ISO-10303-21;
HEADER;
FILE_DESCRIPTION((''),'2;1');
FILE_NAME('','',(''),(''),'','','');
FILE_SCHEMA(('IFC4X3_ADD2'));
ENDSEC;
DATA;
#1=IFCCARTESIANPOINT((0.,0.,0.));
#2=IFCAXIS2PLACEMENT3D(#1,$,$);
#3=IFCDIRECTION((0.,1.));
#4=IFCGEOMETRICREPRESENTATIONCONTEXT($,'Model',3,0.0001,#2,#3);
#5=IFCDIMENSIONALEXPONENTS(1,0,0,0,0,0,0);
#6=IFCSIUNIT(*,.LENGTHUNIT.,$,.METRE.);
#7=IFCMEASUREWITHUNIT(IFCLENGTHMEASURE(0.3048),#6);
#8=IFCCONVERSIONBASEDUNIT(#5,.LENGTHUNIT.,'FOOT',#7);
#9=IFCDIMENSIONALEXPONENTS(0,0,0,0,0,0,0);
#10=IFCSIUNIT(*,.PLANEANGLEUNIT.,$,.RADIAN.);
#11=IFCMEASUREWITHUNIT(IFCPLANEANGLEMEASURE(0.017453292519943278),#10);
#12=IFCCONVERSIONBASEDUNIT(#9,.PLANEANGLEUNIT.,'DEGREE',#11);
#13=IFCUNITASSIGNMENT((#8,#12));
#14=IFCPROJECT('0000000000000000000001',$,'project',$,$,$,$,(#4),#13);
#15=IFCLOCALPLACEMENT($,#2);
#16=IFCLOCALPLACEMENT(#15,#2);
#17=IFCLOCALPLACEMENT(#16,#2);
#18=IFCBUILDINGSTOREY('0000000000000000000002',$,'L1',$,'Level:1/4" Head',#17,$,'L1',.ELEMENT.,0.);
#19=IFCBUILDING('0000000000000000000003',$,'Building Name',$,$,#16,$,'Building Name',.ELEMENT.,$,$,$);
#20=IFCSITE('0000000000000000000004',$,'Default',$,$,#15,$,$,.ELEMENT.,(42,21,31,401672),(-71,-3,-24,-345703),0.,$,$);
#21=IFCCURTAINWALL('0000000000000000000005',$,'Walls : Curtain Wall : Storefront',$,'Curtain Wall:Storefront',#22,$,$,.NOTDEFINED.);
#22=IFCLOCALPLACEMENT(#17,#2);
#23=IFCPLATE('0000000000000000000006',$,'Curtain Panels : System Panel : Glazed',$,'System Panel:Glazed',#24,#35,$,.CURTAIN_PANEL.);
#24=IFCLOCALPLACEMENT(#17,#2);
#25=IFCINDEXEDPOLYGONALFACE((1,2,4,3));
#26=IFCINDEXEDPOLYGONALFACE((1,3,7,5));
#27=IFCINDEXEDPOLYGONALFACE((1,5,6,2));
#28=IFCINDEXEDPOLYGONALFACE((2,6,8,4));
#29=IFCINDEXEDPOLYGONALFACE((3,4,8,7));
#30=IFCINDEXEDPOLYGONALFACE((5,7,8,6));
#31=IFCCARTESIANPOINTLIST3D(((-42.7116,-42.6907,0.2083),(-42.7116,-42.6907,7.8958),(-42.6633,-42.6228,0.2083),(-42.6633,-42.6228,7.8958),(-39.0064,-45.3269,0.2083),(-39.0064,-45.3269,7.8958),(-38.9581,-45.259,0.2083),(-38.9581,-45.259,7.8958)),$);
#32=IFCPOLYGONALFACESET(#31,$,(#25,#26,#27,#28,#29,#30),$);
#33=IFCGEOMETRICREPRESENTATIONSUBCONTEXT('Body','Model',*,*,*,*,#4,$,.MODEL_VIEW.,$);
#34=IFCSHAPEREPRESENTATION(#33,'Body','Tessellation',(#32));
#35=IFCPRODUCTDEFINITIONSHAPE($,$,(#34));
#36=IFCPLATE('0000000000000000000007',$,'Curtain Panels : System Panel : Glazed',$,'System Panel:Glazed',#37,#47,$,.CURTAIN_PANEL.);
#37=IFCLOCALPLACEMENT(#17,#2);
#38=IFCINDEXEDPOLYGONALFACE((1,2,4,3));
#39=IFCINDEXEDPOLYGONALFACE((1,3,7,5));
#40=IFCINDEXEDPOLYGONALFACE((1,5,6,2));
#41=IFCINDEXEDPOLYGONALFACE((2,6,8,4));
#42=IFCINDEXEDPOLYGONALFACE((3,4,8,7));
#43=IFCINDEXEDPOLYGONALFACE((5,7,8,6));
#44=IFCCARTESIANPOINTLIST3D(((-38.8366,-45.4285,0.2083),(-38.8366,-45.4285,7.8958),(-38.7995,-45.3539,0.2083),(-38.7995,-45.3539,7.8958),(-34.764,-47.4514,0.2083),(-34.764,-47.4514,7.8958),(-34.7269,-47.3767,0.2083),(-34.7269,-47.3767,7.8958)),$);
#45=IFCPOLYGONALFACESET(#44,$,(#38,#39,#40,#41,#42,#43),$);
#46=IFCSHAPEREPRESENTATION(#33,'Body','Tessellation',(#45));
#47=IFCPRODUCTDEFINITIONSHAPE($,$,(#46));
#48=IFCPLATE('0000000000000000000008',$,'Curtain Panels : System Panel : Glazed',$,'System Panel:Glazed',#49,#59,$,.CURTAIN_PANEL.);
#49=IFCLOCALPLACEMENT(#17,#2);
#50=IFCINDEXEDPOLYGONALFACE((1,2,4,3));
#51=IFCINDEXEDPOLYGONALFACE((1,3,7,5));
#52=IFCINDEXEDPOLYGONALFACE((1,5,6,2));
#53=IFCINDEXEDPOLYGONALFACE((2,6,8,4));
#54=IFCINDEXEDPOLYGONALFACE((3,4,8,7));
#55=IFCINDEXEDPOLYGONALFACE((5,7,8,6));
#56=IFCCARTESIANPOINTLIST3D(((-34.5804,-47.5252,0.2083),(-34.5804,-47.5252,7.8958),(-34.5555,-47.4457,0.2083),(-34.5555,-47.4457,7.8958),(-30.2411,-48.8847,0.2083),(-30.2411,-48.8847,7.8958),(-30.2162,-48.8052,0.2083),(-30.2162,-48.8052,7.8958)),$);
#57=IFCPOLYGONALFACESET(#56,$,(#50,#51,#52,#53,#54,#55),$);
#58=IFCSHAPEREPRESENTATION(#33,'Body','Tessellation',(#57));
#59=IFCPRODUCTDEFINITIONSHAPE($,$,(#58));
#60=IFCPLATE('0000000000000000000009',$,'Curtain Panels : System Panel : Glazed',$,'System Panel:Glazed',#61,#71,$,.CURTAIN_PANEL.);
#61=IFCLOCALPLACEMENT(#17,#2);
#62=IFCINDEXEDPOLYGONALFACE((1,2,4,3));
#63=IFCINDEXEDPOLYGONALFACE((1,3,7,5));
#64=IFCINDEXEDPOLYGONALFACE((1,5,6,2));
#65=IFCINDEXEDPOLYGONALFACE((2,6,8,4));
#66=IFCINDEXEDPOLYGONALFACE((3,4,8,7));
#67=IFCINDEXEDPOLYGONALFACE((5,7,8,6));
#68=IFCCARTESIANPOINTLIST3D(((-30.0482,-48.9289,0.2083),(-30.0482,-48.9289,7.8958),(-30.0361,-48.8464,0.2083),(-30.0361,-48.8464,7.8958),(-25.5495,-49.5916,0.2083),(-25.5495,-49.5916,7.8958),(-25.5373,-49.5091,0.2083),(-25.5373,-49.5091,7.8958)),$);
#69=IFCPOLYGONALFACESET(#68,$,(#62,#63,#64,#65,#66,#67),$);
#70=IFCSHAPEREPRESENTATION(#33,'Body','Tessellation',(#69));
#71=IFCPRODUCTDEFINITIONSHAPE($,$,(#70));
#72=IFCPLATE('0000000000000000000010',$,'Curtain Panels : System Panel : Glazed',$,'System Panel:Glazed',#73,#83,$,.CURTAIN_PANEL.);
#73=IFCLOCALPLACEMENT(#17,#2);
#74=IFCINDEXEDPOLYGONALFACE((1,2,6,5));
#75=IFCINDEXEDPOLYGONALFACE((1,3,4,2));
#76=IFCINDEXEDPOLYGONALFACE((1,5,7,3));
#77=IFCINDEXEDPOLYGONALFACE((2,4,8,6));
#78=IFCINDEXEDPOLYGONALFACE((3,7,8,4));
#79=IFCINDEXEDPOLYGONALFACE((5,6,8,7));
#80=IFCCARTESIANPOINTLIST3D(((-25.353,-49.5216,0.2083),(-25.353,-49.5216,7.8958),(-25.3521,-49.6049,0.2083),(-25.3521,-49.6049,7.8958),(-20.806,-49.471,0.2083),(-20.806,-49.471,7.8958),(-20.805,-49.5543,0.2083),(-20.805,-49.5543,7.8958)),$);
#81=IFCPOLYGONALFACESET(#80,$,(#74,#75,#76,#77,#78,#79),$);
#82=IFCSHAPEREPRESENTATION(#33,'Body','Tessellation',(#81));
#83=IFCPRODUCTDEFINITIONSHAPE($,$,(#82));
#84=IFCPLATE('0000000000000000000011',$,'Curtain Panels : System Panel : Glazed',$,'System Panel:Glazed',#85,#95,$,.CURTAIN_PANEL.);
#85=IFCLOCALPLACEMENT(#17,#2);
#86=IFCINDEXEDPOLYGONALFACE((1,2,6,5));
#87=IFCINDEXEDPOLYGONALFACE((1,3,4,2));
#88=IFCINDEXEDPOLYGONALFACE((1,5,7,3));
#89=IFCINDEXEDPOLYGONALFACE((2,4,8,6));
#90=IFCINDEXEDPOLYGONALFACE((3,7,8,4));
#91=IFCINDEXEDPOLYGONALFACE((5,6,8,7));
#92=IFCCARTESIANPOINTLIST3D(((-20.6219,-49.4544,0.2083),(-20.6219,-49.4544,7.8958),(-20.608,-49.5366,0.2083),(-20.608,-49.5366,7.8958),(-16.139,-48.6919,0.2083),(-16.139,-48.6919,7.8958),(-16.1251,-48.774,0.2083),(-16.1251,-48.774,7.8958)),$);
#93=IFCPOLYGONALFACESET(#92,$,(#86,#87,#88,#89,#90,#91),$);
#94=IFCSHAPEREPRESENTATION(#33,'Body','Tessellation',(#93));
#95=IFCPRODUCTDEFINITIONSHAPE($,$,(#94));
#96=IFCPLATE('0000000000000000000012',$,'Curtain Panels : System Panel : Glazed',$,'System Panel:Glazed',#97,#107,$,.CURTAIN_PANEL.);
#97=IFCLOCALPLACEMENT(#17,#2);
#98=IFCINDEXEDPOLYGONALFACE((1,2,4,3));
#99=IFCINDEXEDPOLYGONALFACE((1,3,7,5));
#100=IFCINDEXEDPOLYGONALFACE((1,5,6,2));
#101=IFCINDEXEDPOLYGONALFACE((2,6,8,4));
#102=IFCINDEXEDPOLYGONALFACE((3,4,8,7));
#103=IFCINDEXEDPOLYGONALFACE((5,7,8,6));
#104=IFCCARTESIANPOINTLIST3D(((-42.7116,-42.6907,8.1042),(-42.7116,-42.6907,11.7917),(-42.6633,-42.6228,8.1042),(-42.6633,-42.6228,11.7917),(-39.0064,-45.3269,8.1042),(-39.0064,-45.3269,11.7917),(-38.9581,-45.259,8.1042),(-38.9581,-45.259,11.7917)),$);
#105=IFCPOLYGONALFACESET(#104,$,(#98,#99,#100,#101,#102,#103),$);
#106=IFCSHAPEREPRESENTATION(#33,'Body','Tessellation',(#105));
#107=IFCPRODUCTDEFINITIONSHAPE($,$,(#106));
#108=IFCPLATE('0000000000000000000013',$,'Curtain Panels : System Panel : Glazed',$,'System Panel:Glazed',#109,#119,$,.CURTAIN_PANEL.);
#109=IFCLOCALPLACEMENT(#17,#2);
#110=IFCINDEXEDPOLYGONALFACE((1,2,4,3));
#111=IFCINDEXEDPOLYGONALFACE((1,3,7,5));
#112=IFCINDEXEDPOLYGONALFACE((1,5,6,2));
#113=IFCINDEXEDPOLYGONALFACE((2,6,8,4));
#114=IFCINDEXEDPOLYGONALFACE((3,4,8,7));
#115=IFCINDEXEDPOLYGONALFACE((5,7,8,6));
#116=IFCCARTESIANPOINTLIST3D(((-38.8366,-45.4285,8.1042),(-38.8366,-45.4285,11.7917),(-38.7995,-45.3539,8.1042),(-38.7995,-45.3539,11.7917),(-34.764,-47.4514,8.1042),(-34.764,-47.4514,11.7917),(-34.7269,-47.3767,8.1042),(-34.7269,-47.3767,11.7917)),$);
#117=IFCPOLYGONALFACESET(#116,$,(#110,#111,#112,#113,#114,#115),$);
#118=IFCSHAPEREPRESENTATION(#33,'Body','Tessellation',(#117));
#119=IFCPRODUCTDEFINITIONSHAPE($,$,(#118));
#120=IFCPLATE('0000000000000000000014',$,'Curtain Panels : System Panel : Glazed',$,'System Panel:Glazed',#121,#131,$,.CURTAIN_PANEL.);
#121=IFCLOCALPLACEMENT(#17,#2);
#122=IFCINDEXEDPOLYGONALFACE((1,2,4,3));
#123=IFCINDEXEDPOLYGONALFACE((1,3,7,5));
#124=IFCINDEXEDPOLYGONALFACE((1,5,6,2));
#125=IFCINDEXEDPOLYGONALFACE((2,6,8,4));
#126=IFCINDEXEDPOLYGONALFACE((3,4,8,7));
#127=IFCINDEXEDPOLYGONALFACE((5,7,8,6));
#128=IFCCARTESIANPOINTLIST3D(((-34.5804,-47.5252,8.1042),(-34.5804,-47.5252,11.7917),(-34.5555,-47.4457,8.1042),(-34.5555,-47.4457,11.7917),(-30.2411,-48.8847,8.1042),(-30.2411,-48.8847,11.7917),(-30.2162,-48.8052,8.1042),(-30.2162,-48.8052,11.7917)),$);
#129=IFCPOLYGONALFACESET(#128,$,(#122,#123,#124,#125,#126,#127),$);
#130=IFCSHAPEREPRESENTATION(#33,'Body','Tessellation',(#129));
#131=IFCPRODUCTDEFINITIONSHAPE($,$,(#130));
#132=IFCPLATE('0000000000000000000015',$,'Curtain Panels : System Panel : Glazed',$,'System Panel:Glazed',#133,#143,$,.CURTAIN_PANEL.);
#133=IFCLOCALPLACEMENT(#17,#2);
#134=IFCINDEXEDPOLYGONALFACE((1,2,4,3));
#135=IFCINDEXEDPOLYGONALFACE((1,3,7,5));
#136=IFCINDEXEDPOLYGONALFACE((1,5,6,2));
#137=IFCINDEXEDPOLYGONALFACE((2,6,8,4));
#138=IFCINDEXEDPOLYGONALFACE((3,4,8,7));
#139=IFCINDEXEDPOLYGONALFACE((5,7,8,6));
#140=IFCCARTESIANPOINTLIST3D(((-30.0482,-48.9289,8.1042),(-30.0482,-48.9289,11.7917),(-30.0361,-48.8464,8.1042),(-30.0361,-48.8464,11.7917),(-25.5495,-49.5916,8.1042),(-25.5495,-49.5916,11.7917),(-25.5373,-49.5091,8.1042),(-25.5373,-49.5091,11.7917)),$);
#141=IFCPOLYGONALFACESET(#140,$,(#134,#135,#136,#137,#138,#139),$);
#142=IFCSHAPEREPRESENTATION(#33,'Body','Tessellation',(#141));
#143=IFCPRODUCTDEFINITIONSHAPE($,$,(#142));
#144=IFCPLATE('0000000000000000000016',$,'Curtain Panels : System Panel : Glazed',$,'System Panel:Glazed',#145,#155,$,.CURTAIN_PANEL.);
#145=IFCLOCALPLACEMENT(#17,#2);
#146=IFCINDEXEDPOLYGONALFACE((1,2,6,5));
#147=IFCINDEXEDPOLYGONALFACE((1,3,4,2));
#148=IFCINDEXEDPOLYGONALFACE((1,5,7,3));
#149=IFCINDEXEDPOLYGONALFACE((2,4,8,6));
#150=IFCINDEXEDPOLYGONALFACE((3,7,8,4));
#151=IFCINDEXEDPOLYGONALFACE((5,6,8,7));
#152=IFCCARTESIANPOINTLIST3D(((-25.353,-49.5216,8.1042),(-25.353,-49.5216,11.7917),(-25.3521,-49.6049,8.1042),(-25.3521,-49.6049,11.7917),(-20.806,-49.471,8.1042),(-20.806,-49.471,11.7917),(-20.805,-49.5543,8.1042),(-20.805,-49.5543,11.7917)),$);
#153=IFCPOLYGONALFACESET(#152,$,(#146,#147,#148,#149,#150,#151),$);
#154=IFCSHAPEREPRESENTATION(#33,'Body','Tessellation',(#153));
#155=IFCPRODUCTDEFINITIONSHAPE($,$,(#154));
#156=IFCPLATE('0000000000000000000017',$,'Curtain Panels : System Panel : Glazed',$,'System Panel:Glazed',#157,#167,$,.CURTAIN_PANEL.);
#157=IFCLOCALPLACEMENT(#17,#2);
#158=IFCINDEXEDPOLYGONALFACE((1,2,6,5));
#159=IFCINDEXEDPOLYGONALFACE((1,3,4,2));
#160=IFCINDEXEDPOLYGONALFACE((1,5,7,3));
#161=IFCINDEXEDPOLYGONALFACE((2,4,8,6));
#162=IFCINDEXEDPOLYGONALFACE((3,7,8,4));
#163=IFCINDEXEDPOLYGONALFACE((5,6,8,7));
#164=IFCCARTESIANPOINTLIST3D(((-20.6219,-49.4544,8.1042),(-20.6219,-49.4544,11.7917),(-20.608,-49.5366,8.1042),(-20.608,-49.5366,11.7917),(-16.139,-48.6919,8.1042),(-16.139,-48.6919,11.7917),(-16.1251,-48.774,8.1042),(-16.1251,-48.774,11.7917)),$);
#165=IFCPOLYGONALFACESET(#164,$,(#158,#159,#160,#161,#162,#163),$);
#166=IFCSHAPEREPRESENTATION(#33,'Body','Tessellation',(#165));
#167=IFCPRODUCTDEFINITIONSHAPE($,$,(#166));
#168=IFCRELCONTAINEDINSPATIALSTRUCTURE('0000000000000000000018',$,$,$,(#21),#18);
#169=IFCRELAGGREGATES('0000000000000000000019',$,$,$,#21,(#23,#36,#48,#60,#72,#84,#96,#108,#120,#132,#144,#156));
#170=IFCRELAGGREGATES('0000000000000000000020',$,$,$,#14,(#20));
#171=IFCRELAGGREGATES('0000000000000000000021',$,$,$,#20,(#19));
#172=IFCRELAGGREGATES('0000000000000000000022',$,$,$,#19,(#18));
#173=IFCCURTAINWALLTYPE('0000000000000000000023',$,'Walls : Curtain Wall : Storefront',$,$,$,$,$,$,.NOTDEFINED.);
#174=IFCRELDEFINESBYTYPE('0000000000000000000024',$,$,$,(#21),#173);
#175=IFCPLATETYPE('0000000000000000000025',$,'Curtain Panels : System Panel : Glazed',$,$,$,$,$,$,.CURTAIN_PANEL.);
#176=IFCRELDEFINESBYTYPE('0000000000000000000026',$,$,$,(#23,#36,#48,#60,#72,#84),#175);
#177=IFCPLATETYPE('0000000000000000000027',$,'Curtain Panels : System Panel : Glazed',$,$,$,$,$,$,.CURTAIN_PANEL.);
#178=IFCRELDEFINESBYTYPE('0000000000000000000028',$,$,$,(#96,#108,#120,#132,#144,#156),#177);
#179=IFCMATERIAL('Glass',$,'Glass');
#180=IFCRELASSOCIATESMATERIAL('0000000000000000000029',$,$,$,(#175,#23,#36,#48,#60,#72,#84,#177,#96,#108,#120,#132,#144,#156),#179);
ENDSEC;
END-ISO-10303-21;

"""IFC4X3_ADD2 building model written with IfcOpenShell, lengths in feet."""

from ifc_helpers import new_model, entity, si_unit, converted_unit, direction, frame, frame_2d, origin, place, context, subcontext, project, spatial, rectangle, extrude, source, transform, mapped, material, type_object, type_shapes, element, aggregate, save


model = new_model("IFC4X3_ADD2")

# Units and contexts
model_context = context("Model", 3, precision=0.0001, world=origin(), true_north=direction((0.0, 1.0)))
body_context = subcontext(model_context, "Body", "Model", "MODEL_VIEW")
ifc_project = project(units=[converted_unit("LENGTHUNIT", "FOOT", entity("IfcLengthMeasure", 0.3048), si_unit("LENGTHUNIT", "METRE"), dimensions=[1, 0, 0, 0, 0, 0, 0]), converted_unit("PLANEANGLEUNIT", "DEGREE", entity("IfcPlaneAngleMeasure", 0.017453292519943278), si_unit("PLANEANGLEUNIT", "RADIAN"), dimensions=[0, 0, 0, 0, 0, 0, 0])], contexts=[model_context])

# Site, building, storey
site_placement = place(None, origin())
site = spatial("IfcSite", under=ifc_project, at=site_placement, Name="Default", CompositionType="ELEMENT", RefLatitude=(42, 21, 31, 401672), RefLongitude=(-71, -3, -24, -345703), RefElevation=0.0)
building_placement = place(site_placement, origin())
building = spatial("IfcBuilding", under=site, at=building_placement, Name="Building Name", LongName="Building Name", CompositionType="ELEMENT")
storey_placement = place(building_placement, origin())
storey = spatial("IfcBuildingStorey", under=building, at=storey_placement, Name="L1", ObjectType="Level:1/4\" Head", LongName="L1", CompositionType="ELEMENT", Elevation=0.0)

# Curtain wall, plates
curtain_wall_type = type_object("IfcCurtainWallType", Name="Walls : Curtain Wall : Storefront", PredefinedType="NOTDEFINED")
curtain_wall_placement = place(storey_placement, origin())
curtain_wall = element("IfcCurtainWall", 1, at=curtain_wall_placement, inside=storey, type_object=curtain_wall_type, Name="Walls : Curtain Wall : Storefront", ObjectType="Curtain Wall:Storefront", PredefinedType="NOTDEFINED")
ifc_material_1 = material(Name="Glass", Category="Glass")
plate_type_1 = type_object("IfcPlateType", Name="Curtain Panels : System Panel : Glazed", PredefinedType="CURTAIN_PANEL", material=ifc_material_1)
shared_shape_1 = source(origin(), body_context, "Body", "SweptSolid", [
    extrude(rectangle(XDim=0.0833, YDim=4.5473, at=frame_2d((0.0, 0.0), x_axis=(1.0, 0.0))), frame((2.2737, 0.0417, 0.0), z_axis=(0.0, 0.0, 1.0), x_axis=(0.0, 1.0, 0.0)), (0.0, 0.0, 1.0), 7.6875),
])
type_shapes(plate_type_1, [shared_shape_1])
plate_1_placement = place(curtain_wall_placement, frame((-42.7116, -42.6907, 0.2083), z_axis=(0.0, 0.0, 1.0), x_axis=(0.814824, -0.579708, 0.0)))
plate_1 = element("IfcPlate", 2, at=plate_1_placement, type_object=plate_type_1, material=ifc_material_1, Name="Curtain Panels : System Panel : Glazed", ObjectType="System Panel:Glazed", PredefinedType="CURTAIN_PANEL", context=body_context, shape_type="MappedRepresentation", body=[
    mapped(shared_shape_1, transform((0.0, 0.0, 0.0), scale=1.0)),
])
plate_2_placement = place(curtain_wall_placement, frame((-38.8366, -45.4285, 0.2083), z_axis=(0.0, 0.0, 1.0), x_axis=(0.895609, -0.444842, 0.0)))
plate_2 = element("IfcPlate", 3, at=plate_2_placement, type_object=plate_type_1, material=ifc_material_1, Name="Curtain Panels : System Panel : Glazed", ObjectType="System Panel:Glazed", PredefinedType="CURTAIN_PANEL", context=body_context, shape_type="MappedRepresentation", body=[
    mapped(shared_shape_1, transform((0.0, 0.0, 0.0), scale=1.0)),
])
plate_3_placement = place(curtain_wall_placement, frame((-34.5804, -47.5252, 0.2083), z_axis=(0.0, 0.0, 1.0), x_axis=(0.954259, -0.298981, 0.0)))
plate_3 = element("IfcPlate", 4, at=plate_3_placement, type_object=plate_type_1, material=ifc_material_1, Name="Curtain Panels : System Panel : Glazed", ObjectType="System Panel:Glazed", PredefinedType="CURTAIN_PANEL", context=body_context, shape_type="MappedRepresentation", body=[
    mapped(shared_shape_1, transform((0.0, 0.0, 0.0), scale=1.0)),
])
plate_4_placement = place(curtain_wall_placement, frame((-30.0482, -48.9289, 0.2083), z_axis=(0.0, 0.0, 1.0), x_axis=(0.989324, -0.145731, 0.0)))
plate_4 = element("IfcPlate", 5, at=plate_4_placement, type_object=plate_type_1, material=ifc_material_1, Name="Curtain Panels : System Panel : Glazed", ObjectType="System Panel:Glazed", PredefinedType="CURTAIN_PANEL", context=body_context, shape_type="MappedRepresentation", body=[
    mapped(shared_shape_1, transform((0.0, 0.0, 0.0), scale=1.0)),
])
plate_5_placement = place(curtain_wall_placement, frame((-25.3521, -49.6049, 0.2083), z_axis=(0.0, 0.0, 1.0), x_axis=(0.999938, 0.011121, 0.0)))
plate_5 = element("IfcPlate", 6, at=plate_5_placement, type_object=plate_type_1, material=ifc_material_1, Name="Curtain Panels : System Panel : Glazed", ObjectType="System Panel:Glazed", PredefinedType="CURTAIN_PANEL", context=body_context, shape_type="MappedRepresentation", body=[
    mapped(shared_shape_1, transform((0.0, 0.0, 0.0), scale=1.0)),
])
plate_6_placement = place(curtain_wall_placement, frame((-20.608, -49.5366, 0.2083), z_axis=(0.0, 0.0, 1.0), x_axis=(0.985838, 0.167698, 0.0)))
plate_6 = element("IfcPlate", 7, at=plate_6_placement, type_object=plate_type_1, material=ifc_material_1, Name="Curtain Panels : System Panel : Glazed", ObjectType="System Panel:Glazed", PredefinedType="CURTAIN_PANEL", context=body_context, shape_type="MappedRepresentation", body=[
    mapped(shared_shape_1, transform((0.0, 0.0, 0.0), scale=1.0)),
])
plate_type_2 = type_object("IfcPlateType", Name="Curtain Panels : System Panel : Glazed", PredefinedType="CURTAIN_PANEL", material=ifc_material_1)
shared_shape_2 = source(origin(), body_context, "Body", "SweptSolid", [
    extrude(rectangle(XDim=0.0833, YDim=4.5473, at=frame_2d((0.0, 0.0), x_axis=(1.0, 0.0))), frame((2.2737, 0.0417, 0.0), z_axis=(0.0, 0.0, 1.0), x_axis=(0.0, 1.0, 0.0)), (0.0, 0.0, 1.0), 3.6875),
])
type_shapes(plate_type_2, [shared_shape_2])
plate_7_placement = place(curtain_wall_placement, frame((-42.7116, -42.6907, 8.1042), z_axis=(0.0, 0.0, 1.0), x_axis=(0.814824, -0.579708, 0.0)))
plate_7 = element("IfcPlate", 8, at=plate_7_placement, type_object=plate_type_2, material=ifc_material_1, Name="Curtain Panels : System Panel : Glazed", ObjectType="System Panel:Glazed", PredefinedType="CURTAIN_PANEL", context=body_context, shape_type="MappedRepresentation", body=[
    mapped(shared_shape_2, transform((0.0, 0.0, 0.0), scale=1.0)),
])
plate_8_placement = place(curtain_wall_placement, frame((-38.8366, -45.4285, 8.1042), z_axis=(0.0, 0.0, 1.0), x_axis=(0.895609, -0.444842, 0.0)))
plate_8 = element("IfcPlate", 9, at=plate_8_placement, type_object=plate_type_2, material=ifc_material_1, Name="Curtain Panels : System Panel : Glazed", ObjectType="System Panel:Glazed", PredefinedType="CURTAIN_PANEL", context=body_context, shape_type="MappedRepresentation", body=[
    mapped(shared_shape_2, transform((0.0, 0.0, 0.0), scale=1.0)),
])
plate_9_placement = place(curtain_wall_placement, frame((-34.5804, -47.5252, 8.1042), z_axis=(0.0, 0.0, 1.0), x_axis=(0.954259, -0.298981, 0.0)))
plate_9 = element("IfcPlate", 10, at=plate_9_placement, type_object=plate_type_2, material=ifc_material_1, Name="Curtain Panels : System Panel : Glazed", ObjectType="System Panel:Glazed", PredefinedType="CURTAIN_PANEL", context=body_context, shape_type="MappedRepresentation", body=[
    mapped(shared_shape_2, transform((0.0, 0.0, 0.0), scale=1.0)),
])
plate_10_placement = place(curtain_wall_placement, frame((-30.0482, -48.9289, 8.1042), z_axis=(0.0, 0.0, 1.0), x_axis=(0.989324, -0.145731, 0.0)))
plate_10 = element("IfcPlate", 11, at=plate_10_placement, type_object=plate_type_2, material=ifc_material_1, Name="Curtain Panels : System Panel : Glazed", ObjectType="System Panel:Glazed", PredefinedType="CURTAIN_PANEL", context=body_context, shape_type="MappedRepresentation", body=[
    mapped(shared_shape_2, transform((0.0, 0.0, 0.0), scale=1.0)),
])
plate_11_placement = place(curtain_wall_placement, frame((-25.3521, -49.6049, 8.1042), z_axis=(0.0, 0.0, 1.0), x_axis=(0.999938, 0.011121, 0.0)))
plate_11 = element("IfcPlate", 12, at=plate_11_placement, type_object=plate_type_2, material=ifc_material_1, Name="Curtain Panels : System Panel : Glazed", ObjectType="System Panel:Glazed", PredefinedType="CURTAIN_PANEL", context=body_context, shape_type="MappedRepresentation", body=[
    mapped(shared_shape_2, transform((0.0, 0.0, 0.0), scale=1.0)),
])
plate_12_placement = place(curtain_wall_placement, frame((-20.608, -49.5366, 8.1042), z_axis=(0.0, 0.0, 1.0), x_axis=(0.985838, 0.167698, 0.0)))
plate_12 = element("IfcPlate", 13, at=plate_12_placement, type_object=plate_type_2, material=ifc_material_1, Name="Curtain Panels : System Panel : Glazed", ObjectType="System Panel:Glazed", PredefinedType="CURTAIN_PANEL", context=body_context, shape_type="MappedRepresentation", body=[
    mapped(shared_shape_2, transform((0.0, 0.0, 0.0), scale=1.0)),
])
aggregate(curtain_wall, [plate_1, plate_2, plate_3, plate_4, plate_5, plate_6, plate_7, plate_8, plate_9, plate_10, plate_11, plate_12])

save(model, "model.ifc")
